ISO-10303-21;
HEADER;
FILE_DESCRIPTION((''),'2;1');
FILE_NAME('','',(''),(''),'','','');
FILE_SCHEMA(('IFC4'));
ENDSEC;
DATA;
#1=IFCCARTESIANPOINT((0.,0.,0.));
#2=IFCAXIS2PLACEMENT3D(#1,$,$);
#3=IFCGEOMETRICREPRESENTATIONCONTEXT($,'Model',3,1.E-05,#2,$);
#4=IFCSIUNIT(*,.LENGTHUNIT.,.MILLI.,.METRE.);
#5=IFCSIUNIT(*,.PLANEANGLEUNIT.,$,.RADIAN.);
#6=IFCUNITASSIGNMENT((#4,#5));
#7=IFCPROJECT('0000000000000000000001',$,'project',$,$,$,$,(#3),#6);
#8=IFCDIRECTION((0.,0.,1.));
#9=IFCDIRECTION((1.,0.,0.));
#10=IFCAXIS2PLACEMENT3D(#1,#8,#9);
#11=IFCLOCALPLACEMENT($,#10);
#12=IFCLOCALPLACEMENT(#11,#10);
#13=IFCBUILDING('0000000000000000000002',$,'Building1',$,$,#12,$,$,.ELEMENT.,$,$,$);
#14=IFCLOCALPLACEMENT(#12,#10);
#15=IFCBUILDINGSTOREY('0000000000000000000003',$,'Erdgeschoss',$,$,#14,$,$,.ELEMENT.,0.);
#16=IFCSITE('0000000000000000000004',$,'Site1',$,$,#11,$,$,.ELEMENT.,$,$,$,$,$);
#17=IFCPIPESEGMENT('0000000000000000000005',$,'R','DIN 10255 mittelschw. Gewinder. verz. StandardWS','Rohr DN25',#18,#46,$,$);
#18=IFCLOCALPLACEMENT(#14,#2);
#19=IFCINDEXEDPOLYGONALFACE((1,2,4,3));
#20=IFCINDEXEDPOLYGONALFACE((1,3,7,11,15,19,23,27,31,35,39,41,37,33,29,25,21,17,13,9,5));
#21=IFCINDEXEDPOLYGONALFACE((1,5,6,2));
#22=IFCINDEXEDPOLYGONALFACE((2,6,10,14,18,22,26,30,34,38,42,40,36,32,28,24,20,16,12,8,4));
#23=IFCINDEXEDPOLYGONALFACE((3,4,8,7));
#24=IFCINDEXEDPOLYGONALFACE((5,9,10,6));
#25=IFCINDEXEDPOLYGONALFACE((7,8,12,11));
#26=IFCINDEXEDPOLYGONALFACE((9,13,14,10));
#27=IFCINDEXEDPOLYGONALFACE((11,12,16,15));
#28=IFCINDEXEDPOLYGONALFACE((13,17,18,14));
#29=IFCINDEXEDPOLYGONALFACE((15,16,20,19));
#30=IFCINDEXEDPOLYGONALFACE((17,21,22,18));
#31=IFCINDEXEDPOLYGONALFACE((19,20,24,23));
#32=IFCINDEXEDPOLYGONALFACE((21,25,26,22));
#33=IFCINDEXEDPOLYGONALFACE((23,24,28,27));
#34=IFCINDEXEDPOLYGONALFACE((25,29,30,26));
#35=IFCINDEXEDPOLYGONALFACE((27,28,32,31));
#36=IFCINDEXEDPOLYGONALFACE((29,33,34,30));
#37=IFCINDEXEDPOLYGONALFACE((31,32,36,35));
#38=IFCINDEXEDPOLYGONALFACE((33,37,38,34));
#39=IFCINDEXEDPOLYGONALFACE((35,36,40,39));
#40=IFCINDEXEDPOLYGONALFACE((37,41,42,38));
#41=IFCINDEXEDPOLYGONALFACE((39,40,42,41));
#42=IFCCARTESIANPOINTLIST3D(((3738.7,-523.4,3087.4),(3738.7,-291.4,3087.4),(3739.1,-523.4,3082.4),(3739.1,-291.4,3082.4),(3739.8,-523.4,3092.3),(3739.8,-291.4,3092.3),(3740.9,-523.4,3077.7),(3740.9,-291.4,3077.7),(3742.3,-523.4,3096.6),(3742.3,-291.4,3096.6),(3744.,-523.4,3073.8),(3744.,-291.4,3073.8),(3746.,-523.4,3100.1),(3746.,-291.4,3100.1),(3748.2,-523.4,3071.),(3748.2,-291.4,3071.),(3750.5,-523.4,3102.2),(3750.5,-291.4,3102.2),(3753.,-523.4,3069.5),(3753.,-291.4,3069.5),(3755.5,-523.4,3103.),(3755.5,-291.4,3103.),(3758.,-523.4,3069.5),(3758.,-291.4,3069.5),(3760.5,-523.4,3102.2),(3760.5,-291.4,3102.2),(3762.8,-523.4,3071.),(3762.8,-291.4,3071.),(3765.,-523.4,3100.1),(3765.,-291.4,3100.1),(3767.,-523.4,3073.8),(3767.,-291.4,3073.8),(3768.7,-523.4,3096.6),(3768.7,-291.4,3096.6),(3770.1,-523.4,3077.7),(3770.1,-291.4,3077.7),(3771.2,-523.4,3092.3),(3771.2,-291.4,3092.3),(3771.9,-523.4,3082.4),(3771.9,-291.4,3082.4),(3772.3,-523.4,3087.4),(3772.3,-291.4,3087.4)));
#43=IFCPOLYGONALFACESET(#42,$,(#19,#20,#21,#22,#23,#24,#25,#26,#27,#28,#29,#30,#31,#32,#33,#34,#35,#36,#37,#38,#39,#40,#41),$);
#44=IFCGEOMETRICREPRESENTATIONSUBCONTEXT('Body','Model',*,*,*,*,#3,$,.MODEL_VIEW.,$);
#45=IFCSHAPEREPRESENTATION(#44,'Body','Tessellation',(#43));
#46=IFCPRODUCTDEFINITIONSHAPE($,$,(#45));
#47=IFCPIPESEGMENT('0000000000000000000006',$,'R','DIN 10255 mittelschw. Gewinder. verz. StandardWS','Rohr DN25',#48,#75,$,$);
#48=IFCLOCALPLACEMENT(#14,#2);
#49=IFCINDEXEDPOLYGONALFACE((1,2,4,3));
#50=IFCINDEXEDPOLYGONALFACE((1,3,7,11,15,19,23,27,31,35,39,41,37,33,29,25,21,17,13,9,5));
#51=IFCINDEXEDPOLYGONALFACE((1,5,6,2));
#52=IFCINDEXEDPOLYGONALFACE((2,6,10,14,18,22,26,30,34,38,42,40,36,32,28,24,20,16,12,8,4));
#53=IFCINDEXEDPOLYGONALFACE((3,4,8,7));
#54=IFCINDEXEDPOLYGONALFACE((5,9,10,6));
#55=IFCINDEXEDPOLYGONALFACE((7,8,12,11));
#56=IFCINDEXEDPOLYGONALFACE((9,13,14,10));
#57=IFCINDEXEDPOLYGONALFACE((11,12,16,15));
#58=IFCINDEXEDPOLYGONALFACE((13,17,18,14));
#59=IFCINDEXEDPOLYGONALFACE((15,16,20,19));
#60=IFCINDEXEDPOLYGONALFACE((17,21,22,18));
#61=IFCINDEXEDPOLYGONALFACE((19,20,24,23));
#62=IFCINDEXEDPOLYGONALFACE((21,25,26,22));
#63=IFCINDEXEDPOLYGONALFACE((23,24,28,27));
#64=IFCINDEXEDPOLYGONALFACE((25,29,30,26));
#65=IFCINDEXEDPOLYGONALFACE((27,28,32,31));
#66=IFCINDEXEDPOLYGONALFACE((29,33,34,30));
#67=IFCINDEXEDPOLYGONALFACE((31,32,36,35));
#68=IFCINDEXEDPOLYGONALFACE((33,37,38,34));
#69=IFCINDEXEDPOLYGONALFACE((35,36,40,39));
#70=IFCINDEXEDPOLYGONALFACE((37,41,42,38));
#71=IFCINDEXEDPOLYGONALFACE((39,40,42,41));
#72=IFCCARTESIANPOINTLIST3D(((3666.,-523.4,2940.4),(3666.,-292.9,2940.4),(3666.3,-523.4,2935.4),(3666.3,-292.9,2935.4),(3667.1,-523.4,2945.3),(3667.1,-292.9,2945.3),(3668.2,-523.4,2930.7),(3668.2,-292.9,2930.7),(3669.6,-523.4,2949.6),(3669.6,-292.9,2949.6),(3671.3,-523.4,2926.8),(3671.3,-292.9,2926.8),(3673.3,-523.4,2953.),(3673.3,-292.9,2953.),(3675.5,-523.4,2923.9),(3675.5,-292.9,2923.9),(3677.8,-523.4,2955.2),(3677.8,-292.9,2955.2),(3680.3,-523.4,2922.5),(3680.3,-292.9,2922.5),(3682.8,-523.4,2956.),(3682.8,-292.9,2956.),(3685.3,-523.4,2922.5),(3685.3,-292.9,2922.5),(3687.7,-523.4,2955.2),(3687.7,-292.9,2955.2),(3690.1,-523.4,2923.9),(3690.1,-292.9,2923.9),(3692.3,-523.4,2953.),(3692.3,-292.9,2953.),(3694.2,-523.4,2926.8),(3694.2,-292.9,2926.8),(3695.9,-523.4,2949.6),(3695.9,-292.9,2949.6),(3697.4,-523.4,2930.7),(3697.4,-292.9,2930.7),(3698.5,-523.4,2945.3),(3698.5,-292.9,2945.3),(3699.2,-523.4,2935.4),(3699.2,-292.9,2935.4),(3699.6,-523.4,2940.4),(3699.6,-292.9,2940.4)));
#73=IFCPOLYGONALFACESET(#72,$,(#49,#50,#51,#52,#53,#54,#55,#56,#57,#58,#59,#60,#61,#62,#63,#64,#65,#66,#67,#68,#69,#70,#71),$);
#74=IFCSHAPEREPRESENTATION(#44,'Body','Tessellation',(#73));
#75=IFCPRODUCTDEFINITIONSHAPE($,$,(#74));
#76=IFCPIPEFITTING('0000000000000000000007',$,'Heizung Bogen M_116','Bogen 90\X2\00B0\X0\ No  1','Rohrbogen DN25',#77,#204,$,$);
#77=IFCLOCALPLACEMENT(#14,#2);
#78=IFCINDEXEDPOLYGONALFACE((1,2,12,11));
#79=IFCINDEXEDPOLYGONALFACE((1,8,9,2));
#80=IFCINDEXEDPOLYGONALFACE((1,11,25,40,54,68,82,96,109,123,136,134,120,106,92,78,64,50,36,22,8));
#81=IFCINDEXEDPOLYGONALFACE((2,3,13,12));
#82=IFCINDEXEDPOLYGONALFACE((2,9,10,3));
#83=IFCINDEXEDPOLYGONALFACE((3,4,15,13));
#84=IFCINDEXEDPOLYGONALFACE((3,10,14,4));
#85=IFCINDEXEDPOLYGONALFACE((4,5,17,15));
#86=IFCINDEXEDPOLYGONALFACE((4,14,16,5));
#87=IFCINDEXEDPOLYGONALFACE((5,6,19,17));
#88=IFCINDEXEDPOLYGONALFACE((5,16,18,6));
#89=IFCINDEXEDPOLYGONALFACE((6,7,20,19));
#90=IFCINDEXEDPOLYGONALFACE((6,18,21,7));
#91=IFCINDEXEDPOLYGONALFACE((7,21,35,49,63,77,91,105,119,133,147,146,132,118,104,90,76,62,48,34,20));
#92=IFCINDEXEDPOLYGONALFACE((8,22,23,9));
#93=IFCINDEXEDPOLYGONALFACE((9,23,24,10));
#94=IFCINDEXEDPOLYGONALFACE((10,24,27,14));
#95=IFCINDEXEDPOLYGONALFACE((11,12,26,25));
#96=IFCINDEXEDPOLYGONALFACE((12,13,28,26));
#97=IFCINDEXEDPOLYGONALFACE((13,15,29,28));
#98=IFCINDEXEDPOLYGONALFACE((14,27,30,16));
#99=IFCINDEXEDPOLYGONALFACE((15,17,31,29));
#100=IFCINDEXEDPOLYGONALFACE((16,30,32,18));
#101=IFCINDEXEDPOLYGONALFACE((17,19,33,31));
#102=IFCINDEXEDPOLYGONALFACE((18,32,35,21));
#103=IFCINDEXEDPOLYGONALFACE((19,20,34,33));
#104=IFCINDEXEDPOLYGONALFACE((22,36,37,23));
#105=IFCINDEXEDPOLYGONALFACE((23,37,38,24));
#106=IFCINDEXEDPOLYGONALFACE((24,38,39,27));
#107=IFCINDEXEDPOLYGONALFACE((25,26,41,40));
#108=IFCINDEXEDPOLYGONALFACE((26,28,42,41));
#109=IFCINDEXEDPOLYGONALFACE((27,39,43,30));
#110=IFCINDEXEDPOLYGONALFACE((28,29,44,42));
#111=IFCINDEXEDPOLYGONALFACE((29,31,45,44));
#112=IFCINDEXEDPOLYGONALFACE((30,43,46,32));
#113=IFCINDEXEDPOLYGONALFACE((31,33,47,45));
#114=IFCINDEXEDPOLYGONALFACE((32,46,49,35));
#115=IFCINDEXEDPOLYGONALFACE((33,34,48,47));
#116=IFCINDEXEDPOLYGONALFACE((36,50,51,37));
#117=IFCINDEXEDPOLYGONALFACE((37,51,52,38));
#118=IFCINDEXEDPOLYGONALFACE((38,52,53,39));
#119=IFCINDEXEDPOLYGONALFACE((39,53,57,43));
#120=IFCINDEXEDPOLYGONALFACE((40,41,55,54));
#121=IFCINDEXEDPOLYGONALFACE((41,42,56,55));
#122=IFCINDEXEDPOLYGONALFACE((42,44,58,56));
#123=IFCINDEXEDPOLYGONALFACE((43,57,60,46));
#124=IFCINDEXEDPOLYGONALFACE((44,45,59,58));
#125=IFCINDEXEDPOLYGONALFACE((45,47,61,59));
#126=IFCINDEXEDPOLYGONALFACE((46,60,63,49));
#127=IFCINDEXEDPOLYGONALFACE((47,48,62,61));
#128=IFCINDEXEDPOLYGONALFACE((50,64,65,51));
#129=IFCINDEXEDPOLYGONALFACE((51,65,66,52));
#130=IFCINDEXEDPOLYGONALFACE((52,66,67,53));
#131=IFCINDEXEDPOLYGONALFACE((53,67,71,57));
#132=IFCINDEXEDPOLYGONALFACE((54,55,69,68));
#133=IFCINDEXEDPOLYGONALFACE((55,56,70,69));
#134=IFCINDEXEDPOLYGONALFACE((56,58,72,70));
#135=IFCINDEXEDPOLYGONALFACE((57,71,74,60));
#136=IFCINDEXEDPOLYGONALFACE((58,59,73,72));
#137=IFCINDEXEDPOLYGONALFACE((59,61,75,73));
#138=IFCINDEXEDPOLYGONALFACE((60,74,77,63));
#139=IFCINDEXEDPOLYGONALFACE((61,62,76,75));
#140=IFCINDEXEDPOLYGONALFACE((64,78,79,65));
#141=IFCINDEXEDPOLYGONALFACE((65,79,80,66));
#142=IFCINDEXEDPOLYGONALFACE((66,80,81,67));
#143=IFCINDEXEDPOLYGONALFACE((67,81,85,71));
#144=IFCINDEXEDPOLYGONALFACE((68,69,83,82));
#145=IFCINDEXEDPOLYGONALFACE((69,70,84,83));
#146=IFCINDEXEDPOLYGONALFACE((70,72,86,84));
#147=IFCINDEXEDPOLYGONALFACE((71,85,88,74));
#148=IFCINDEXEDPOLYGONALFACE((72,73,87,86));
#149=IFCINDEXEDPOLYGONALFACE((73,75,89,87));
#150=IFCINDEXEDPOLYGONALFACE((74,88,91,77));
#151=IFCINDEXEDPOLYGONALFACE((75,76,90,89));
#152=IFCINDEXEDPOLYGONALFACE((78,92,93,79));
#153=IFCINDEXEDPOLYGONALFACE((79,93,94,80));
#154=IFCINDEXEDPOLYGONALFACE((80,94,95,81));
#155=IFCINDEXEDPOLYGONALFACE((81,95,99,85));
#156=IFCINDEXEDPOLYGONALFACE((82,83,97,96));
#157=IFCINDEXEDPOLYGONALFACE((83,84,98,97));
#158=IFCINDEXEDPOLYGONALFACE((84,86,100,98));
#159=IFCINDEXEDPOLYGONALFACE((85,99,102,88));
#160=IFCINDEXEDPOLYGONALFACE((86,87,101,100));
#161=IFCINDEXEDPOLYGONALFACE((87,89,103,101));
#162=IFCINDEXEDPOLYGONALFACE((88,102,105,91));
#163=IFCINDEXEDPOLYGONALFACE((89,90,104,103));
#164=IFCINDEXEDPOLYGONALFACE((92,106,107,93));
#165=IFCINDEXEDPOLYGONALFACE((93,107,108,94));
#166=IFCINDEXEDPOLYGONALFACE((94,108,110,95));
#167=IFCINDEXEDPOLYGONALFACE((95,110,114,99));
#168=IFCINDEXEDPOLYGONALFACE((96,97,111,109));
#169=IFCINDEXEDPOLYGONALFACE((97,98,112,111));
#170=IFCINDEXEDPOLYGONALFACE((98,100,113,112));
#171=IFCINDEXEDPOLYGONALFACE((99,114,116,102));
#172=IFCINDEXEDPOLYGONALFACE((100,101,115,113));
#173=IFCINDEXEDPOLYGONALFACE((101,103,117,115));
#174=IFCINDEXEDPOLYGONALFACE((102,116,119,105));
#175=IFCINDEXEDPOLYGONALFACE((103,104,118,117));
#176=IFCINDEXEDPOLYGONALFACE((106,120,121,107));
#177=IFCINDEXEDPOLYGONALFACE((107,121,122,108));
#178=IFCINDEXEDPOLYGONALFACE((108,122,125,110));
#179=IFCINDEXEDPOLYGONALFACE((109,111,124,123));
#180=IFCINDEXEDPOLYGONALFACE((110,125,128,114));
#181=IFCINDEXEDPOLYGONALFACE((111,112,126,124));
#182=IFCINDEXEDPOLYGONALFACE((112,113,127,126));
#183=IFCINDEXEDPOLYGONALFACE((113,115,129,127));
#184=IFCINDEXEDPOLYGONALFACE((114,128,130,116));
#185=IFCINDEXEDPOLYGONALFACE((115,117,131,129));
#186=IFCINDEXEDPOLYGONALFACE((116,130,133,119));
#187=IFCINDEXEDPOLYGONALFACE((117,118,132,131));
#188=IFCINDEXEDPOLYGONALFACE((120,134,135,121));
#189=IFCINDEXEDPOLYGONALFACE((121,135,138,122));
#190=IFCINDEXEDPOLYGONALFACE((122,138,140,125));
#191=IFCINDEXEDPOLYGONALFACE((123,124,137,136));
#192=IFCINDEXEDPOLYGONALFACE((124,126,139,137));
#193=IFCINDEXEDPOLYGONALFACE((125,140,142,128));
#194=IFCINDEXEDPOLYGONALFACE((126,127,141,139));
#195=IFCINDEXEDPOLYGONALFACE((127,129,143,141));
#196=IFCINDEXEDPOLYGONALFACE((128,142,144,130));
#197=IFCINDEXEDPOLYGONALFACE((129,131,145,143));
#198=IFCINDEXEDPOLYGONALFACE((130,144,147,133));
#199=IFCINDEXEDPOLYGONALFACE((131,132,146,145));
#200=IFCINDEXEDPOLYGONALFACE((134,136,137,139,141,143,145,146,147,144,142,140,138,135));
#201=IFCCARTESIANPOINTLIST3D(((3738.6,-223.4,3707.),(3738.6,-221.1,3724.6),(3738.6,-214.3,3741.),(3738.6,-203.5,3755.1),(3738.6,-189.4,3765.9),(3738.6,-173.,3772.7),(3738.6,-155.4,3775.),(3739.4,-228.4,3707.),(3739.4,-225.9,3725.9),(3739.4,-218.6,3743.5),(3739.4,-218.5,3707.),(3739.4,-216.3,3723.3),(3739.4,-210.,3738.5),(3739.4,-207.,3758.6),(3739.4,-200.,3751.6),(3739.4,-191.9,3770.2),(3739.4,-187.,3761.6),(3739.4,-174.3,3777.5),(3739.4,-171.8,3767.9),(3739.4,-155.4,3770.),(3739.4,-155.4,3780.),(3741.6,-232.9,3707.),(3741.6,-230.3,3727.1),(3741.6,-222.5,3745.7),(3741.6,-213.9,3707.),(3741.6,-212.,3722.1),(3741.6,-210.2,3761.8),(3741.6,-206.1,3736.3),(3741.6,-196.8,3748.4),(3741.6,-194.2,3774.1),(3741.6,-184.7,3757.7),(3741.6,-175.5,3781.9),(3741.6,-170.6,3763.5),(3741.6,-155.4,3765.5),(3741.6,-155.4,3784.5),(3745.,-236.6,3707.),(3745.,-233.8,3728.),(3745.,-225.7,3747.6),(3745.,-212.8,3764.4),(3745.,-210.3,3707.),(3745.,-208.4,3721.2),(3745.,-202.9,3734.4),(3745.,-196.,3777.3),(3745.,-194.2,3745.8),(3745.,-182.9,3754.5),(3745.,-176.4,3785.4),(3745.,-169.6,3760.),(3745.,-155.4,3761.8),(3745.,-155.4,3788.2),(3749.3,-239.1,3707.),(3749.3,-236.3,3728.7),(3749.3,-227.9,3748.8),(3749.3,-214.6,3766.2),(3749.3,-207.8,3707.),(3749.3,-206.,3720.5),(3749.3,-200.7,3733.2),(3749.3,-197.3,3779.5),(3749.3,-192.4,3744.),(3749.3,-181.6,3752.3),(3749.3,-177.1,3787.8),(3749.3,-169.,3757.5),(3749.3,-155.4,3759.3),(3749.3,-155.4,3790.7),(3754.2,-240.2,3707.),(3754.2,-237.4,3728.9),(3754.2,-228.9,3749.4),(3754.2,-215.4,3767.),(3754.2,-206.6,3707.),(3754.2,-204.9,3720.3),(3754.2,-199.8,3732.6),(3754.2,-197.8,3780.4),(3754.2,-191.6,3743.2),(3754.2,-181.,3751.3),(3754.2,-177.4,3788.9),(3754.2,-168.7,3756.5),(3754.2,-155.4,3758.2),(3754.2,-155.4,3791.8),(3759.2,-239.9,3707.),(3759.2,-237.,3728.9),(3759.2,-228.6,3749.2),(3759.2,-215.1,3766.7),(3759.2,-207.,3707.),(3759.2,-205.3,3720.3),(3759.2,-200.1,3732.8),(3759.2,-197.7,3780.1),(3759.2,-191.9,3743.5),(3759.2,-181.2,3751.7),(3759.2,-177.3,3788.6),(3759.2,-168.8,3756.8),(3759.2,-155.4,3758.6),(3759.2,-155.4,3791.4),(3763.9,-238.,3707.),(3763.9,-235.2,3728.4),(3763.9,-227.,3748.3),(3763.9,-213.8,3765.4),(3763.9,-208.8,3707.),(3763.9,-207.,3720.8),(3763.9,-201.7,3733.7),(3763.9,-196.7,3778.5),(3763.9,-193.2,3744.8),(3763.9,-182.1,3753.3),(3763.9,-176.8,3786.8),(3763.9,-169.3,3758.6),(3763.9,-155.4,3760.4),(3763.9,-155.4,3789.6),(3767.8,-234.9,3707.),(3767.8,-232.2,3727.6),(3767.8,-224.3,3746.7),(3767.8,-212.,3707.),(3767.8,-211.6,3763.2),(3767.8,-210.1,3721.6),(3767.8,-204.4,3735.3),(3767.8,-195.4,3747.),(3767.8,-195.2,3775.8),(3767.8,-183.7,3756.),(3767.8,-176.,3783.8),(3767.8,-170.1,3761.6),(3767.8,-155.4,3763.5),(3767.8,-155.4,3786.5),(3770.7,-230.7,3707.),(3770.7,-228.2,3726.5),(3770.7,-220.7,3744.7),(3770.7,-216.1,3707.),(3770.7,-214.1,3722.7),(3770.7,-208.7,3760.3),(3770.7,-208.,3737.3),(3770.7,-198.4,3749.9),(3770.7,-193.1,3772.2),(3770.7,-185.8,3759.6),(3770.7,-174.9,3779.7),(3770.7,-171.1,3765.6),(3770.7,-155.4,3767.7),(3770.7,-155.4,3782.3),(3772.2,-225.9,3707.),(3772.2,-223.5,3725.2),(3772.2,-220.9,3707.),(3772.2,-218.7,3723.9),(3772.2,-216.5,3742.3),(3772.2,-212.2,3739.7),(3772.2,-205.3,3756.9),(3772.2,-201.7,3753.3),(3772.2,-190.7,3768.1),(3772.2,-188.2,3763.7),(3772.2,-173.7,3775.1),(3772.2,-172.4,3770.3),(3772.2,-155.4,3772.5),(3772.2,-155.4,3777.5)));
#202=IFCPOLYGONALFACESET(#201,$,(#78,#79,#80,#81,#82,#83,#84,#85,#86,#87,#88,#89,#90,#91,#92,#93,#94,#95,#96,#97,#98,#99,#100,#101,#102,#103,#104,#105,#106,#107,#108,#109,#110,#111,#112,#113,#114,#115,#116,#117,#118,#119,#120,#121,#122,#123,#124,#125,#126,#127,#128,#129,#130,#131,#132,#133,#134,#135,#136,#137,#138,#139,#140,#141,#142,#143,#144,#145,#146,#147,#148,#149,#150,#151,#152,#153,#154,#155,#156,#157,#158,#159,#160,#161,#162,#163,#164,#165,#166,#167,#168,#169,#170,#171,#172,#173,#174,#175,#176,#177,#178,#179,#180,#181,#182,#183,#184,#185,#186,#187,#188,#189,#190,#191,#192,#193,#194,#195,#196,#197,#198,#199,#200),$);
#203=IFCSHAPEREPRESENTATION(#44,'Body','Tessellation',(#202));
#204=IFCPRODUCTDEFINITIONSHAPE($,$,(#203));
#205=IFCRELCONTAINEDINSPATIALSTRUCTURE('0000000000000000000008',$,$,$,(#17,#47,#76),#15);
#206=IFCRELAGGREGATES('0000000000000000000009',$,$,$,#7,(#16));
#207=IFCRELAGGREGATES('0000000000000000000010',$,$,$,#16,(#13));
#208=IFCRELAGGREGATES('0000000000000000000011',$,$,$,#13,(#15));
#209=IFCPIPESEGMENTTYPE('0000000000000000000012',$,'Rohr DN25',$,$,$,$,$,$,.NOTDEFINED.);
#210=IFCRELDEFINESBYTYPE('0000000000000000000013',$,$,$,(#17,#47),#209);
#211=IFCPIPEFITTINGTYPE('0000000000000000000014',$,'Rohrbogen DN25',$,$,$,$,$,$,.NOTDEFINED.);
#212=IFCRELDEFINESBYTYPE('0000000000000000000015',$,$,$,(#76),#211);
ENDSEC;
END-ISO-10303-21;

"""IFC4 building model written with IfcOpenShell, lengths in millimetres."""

from ifc_helpers import new_model, entity, si_unit, frame, origin, origin_with_axes, origin_2d_with_axis, place, context, subcontext, project, spatial, circle, extrude, source, transform, mapped, type_object, element, save


model = new_model("IFC4")

# Units and contexts
model_context = context("Model", 3, precision=1e-05, world=origin())
body_context = subcontext(model_context, "Body", "Model", "MODEL_VIEW")
ifc_project = project(units=[si_unit("LENGTHUNIT", "METRE", prefix="MILLI"), si_unit("PLANEANGLEUNIT", "RADIAN")], contexts=[model_context])

# Site, building, storey
site_placement = place(None, origin_with_axes())
site = spatial("IfcSite", under=ifc_project, at=site_placement, Name="Site1", CompositionType="ELEMENT")
building_placement = place(site_placement, origin_with_axes())
building = spatial("IfcBuilding", under=site, at=building_placement, Name="Building1", CompositionType="ELEMENT")
storey_placement = place(building_placement, origin_with_axes())
storey = spatial("IfcBuildingStorey", under=building, at=storey_placement, Name="Erdgeschoss", CompositionType="ELEMENT", Elevation=0.0)

# Pipe segments
pipe_segment_type_1 = type_object("IfcPipeSegmentType", Name="Rohr DN25", PredefinedType="NOTDEFINED")
pipe_segment_1_placement = place(storey_placement, frame((3755.3, -407.4, 3086.1), z_axis=(0.0, 0.0, 1.0), x_axis=(1.0, 0.0, 0.0)))
element("IfcPipeSegment", 1, at=pipe_segment_1_placement, inside=storey, type_object=pipe_segment_type_1, Name="R", Description="DIN 10255 mittelschw. Gewinder. verz. StandardWS", ObjectType="Rohr DN25", context=body_context, shape_type="SolidModel", body=[
    extrude(circle(Radius=16.9, at=origin_2d_with_axis()), frame((0.2, -116.0, 0.0), z_axis=(0.0, 1.0, 0.0), x_axis=(0.0, 0.0, 1.0)), (0.0, 0.0, 1.0), 232.0),
])
pipe_segment_2_placement = place(storey_placement, frame((3682.6, -408.1, 2939.1), z_axis=(0.0, 0.0, 1.0), x_axis=(1.0, 0.0, 0.0)))
element("IfcPipeSegment", 2, at=pipe_segment_2_placement, inside=storey, type_object=pipe_segment_type_1, Name="R", Description="DIN 10255 mittelschw. Gewinder. verz. StandardWS", ObjectType="Rohr DN25", context=body_context, shape_type="SolidModel", body=[
    extrude(circle(Radius=16.9, at=origin_2d_with_axis()), frame((0.2, -115.3, 0.0), z_axis=(0.0, 1.0, 0.0), x_axis=(0.0, 0.0, 1.0)), (0.0, 0.0, 1.0), 230.5),
])

# Pipe fitting
pipe_fitting_type_1 = type_object("IfcPipeFittingType", Name="Rohrbogen DN25", PredefinedType="NOTDEFINED")
shared_shape_1 = source(origin_with_axes(), body_context, "Body", "SolidModel", [
    entity("IfcRevolvedAreaSolid", entity("IfcCircleProfileDef", "AREA", None, entity("IfcAxis2Placement2D", entity("IfcCartesianPoint", [0.0, 0.0]), entity("IfcDirection", [1.0, 0.0])), 16.9), entity("IfcAxis2Placement3D", entity("IfcCartesianPoint", [-42.4, 0.0, 25.6]), entity("IfcDirection", [1.0, 0.0, 0.0]), entity("IfcDirection", [0.0, -1.0, 0.0])), entity("IfcAxis1Placement", entity("IfcCartesianPoint", [0.0, 68.0, 0.0]), entity("IfcDirection", [-1.0, 0.0, 0.0])), 1.570796),
])
pipe_fitting_1_placement = place(storey_placement, frame((3755.5, -197.9, 3749.4), z_axis=(0.0, 0.0, 1.0), x_axis=(1.0, 0.0, 0.0)))
element("IfcPipeFitting", 3, at=pipe_fitting_1_placement, inside=storey, type_object=pipe_fitting_type_1, Name="Heizung Bogen M_116", Description="Bogen 90° No  1", ObjectType="Rohrbogen DN25", context=body_context, shape_type="MappedRepresentation", body=[
    mapped(shared_shape_1, transform((0.0, 0.0, 0.0), x_axis=(0.0, -1.0, 0.0), y_axis=(1.0, 0.0, 0.0), z_axis=(0.0, 0.0, 1.0), scale=1.0)),
])

save(model, "model.ifc")
